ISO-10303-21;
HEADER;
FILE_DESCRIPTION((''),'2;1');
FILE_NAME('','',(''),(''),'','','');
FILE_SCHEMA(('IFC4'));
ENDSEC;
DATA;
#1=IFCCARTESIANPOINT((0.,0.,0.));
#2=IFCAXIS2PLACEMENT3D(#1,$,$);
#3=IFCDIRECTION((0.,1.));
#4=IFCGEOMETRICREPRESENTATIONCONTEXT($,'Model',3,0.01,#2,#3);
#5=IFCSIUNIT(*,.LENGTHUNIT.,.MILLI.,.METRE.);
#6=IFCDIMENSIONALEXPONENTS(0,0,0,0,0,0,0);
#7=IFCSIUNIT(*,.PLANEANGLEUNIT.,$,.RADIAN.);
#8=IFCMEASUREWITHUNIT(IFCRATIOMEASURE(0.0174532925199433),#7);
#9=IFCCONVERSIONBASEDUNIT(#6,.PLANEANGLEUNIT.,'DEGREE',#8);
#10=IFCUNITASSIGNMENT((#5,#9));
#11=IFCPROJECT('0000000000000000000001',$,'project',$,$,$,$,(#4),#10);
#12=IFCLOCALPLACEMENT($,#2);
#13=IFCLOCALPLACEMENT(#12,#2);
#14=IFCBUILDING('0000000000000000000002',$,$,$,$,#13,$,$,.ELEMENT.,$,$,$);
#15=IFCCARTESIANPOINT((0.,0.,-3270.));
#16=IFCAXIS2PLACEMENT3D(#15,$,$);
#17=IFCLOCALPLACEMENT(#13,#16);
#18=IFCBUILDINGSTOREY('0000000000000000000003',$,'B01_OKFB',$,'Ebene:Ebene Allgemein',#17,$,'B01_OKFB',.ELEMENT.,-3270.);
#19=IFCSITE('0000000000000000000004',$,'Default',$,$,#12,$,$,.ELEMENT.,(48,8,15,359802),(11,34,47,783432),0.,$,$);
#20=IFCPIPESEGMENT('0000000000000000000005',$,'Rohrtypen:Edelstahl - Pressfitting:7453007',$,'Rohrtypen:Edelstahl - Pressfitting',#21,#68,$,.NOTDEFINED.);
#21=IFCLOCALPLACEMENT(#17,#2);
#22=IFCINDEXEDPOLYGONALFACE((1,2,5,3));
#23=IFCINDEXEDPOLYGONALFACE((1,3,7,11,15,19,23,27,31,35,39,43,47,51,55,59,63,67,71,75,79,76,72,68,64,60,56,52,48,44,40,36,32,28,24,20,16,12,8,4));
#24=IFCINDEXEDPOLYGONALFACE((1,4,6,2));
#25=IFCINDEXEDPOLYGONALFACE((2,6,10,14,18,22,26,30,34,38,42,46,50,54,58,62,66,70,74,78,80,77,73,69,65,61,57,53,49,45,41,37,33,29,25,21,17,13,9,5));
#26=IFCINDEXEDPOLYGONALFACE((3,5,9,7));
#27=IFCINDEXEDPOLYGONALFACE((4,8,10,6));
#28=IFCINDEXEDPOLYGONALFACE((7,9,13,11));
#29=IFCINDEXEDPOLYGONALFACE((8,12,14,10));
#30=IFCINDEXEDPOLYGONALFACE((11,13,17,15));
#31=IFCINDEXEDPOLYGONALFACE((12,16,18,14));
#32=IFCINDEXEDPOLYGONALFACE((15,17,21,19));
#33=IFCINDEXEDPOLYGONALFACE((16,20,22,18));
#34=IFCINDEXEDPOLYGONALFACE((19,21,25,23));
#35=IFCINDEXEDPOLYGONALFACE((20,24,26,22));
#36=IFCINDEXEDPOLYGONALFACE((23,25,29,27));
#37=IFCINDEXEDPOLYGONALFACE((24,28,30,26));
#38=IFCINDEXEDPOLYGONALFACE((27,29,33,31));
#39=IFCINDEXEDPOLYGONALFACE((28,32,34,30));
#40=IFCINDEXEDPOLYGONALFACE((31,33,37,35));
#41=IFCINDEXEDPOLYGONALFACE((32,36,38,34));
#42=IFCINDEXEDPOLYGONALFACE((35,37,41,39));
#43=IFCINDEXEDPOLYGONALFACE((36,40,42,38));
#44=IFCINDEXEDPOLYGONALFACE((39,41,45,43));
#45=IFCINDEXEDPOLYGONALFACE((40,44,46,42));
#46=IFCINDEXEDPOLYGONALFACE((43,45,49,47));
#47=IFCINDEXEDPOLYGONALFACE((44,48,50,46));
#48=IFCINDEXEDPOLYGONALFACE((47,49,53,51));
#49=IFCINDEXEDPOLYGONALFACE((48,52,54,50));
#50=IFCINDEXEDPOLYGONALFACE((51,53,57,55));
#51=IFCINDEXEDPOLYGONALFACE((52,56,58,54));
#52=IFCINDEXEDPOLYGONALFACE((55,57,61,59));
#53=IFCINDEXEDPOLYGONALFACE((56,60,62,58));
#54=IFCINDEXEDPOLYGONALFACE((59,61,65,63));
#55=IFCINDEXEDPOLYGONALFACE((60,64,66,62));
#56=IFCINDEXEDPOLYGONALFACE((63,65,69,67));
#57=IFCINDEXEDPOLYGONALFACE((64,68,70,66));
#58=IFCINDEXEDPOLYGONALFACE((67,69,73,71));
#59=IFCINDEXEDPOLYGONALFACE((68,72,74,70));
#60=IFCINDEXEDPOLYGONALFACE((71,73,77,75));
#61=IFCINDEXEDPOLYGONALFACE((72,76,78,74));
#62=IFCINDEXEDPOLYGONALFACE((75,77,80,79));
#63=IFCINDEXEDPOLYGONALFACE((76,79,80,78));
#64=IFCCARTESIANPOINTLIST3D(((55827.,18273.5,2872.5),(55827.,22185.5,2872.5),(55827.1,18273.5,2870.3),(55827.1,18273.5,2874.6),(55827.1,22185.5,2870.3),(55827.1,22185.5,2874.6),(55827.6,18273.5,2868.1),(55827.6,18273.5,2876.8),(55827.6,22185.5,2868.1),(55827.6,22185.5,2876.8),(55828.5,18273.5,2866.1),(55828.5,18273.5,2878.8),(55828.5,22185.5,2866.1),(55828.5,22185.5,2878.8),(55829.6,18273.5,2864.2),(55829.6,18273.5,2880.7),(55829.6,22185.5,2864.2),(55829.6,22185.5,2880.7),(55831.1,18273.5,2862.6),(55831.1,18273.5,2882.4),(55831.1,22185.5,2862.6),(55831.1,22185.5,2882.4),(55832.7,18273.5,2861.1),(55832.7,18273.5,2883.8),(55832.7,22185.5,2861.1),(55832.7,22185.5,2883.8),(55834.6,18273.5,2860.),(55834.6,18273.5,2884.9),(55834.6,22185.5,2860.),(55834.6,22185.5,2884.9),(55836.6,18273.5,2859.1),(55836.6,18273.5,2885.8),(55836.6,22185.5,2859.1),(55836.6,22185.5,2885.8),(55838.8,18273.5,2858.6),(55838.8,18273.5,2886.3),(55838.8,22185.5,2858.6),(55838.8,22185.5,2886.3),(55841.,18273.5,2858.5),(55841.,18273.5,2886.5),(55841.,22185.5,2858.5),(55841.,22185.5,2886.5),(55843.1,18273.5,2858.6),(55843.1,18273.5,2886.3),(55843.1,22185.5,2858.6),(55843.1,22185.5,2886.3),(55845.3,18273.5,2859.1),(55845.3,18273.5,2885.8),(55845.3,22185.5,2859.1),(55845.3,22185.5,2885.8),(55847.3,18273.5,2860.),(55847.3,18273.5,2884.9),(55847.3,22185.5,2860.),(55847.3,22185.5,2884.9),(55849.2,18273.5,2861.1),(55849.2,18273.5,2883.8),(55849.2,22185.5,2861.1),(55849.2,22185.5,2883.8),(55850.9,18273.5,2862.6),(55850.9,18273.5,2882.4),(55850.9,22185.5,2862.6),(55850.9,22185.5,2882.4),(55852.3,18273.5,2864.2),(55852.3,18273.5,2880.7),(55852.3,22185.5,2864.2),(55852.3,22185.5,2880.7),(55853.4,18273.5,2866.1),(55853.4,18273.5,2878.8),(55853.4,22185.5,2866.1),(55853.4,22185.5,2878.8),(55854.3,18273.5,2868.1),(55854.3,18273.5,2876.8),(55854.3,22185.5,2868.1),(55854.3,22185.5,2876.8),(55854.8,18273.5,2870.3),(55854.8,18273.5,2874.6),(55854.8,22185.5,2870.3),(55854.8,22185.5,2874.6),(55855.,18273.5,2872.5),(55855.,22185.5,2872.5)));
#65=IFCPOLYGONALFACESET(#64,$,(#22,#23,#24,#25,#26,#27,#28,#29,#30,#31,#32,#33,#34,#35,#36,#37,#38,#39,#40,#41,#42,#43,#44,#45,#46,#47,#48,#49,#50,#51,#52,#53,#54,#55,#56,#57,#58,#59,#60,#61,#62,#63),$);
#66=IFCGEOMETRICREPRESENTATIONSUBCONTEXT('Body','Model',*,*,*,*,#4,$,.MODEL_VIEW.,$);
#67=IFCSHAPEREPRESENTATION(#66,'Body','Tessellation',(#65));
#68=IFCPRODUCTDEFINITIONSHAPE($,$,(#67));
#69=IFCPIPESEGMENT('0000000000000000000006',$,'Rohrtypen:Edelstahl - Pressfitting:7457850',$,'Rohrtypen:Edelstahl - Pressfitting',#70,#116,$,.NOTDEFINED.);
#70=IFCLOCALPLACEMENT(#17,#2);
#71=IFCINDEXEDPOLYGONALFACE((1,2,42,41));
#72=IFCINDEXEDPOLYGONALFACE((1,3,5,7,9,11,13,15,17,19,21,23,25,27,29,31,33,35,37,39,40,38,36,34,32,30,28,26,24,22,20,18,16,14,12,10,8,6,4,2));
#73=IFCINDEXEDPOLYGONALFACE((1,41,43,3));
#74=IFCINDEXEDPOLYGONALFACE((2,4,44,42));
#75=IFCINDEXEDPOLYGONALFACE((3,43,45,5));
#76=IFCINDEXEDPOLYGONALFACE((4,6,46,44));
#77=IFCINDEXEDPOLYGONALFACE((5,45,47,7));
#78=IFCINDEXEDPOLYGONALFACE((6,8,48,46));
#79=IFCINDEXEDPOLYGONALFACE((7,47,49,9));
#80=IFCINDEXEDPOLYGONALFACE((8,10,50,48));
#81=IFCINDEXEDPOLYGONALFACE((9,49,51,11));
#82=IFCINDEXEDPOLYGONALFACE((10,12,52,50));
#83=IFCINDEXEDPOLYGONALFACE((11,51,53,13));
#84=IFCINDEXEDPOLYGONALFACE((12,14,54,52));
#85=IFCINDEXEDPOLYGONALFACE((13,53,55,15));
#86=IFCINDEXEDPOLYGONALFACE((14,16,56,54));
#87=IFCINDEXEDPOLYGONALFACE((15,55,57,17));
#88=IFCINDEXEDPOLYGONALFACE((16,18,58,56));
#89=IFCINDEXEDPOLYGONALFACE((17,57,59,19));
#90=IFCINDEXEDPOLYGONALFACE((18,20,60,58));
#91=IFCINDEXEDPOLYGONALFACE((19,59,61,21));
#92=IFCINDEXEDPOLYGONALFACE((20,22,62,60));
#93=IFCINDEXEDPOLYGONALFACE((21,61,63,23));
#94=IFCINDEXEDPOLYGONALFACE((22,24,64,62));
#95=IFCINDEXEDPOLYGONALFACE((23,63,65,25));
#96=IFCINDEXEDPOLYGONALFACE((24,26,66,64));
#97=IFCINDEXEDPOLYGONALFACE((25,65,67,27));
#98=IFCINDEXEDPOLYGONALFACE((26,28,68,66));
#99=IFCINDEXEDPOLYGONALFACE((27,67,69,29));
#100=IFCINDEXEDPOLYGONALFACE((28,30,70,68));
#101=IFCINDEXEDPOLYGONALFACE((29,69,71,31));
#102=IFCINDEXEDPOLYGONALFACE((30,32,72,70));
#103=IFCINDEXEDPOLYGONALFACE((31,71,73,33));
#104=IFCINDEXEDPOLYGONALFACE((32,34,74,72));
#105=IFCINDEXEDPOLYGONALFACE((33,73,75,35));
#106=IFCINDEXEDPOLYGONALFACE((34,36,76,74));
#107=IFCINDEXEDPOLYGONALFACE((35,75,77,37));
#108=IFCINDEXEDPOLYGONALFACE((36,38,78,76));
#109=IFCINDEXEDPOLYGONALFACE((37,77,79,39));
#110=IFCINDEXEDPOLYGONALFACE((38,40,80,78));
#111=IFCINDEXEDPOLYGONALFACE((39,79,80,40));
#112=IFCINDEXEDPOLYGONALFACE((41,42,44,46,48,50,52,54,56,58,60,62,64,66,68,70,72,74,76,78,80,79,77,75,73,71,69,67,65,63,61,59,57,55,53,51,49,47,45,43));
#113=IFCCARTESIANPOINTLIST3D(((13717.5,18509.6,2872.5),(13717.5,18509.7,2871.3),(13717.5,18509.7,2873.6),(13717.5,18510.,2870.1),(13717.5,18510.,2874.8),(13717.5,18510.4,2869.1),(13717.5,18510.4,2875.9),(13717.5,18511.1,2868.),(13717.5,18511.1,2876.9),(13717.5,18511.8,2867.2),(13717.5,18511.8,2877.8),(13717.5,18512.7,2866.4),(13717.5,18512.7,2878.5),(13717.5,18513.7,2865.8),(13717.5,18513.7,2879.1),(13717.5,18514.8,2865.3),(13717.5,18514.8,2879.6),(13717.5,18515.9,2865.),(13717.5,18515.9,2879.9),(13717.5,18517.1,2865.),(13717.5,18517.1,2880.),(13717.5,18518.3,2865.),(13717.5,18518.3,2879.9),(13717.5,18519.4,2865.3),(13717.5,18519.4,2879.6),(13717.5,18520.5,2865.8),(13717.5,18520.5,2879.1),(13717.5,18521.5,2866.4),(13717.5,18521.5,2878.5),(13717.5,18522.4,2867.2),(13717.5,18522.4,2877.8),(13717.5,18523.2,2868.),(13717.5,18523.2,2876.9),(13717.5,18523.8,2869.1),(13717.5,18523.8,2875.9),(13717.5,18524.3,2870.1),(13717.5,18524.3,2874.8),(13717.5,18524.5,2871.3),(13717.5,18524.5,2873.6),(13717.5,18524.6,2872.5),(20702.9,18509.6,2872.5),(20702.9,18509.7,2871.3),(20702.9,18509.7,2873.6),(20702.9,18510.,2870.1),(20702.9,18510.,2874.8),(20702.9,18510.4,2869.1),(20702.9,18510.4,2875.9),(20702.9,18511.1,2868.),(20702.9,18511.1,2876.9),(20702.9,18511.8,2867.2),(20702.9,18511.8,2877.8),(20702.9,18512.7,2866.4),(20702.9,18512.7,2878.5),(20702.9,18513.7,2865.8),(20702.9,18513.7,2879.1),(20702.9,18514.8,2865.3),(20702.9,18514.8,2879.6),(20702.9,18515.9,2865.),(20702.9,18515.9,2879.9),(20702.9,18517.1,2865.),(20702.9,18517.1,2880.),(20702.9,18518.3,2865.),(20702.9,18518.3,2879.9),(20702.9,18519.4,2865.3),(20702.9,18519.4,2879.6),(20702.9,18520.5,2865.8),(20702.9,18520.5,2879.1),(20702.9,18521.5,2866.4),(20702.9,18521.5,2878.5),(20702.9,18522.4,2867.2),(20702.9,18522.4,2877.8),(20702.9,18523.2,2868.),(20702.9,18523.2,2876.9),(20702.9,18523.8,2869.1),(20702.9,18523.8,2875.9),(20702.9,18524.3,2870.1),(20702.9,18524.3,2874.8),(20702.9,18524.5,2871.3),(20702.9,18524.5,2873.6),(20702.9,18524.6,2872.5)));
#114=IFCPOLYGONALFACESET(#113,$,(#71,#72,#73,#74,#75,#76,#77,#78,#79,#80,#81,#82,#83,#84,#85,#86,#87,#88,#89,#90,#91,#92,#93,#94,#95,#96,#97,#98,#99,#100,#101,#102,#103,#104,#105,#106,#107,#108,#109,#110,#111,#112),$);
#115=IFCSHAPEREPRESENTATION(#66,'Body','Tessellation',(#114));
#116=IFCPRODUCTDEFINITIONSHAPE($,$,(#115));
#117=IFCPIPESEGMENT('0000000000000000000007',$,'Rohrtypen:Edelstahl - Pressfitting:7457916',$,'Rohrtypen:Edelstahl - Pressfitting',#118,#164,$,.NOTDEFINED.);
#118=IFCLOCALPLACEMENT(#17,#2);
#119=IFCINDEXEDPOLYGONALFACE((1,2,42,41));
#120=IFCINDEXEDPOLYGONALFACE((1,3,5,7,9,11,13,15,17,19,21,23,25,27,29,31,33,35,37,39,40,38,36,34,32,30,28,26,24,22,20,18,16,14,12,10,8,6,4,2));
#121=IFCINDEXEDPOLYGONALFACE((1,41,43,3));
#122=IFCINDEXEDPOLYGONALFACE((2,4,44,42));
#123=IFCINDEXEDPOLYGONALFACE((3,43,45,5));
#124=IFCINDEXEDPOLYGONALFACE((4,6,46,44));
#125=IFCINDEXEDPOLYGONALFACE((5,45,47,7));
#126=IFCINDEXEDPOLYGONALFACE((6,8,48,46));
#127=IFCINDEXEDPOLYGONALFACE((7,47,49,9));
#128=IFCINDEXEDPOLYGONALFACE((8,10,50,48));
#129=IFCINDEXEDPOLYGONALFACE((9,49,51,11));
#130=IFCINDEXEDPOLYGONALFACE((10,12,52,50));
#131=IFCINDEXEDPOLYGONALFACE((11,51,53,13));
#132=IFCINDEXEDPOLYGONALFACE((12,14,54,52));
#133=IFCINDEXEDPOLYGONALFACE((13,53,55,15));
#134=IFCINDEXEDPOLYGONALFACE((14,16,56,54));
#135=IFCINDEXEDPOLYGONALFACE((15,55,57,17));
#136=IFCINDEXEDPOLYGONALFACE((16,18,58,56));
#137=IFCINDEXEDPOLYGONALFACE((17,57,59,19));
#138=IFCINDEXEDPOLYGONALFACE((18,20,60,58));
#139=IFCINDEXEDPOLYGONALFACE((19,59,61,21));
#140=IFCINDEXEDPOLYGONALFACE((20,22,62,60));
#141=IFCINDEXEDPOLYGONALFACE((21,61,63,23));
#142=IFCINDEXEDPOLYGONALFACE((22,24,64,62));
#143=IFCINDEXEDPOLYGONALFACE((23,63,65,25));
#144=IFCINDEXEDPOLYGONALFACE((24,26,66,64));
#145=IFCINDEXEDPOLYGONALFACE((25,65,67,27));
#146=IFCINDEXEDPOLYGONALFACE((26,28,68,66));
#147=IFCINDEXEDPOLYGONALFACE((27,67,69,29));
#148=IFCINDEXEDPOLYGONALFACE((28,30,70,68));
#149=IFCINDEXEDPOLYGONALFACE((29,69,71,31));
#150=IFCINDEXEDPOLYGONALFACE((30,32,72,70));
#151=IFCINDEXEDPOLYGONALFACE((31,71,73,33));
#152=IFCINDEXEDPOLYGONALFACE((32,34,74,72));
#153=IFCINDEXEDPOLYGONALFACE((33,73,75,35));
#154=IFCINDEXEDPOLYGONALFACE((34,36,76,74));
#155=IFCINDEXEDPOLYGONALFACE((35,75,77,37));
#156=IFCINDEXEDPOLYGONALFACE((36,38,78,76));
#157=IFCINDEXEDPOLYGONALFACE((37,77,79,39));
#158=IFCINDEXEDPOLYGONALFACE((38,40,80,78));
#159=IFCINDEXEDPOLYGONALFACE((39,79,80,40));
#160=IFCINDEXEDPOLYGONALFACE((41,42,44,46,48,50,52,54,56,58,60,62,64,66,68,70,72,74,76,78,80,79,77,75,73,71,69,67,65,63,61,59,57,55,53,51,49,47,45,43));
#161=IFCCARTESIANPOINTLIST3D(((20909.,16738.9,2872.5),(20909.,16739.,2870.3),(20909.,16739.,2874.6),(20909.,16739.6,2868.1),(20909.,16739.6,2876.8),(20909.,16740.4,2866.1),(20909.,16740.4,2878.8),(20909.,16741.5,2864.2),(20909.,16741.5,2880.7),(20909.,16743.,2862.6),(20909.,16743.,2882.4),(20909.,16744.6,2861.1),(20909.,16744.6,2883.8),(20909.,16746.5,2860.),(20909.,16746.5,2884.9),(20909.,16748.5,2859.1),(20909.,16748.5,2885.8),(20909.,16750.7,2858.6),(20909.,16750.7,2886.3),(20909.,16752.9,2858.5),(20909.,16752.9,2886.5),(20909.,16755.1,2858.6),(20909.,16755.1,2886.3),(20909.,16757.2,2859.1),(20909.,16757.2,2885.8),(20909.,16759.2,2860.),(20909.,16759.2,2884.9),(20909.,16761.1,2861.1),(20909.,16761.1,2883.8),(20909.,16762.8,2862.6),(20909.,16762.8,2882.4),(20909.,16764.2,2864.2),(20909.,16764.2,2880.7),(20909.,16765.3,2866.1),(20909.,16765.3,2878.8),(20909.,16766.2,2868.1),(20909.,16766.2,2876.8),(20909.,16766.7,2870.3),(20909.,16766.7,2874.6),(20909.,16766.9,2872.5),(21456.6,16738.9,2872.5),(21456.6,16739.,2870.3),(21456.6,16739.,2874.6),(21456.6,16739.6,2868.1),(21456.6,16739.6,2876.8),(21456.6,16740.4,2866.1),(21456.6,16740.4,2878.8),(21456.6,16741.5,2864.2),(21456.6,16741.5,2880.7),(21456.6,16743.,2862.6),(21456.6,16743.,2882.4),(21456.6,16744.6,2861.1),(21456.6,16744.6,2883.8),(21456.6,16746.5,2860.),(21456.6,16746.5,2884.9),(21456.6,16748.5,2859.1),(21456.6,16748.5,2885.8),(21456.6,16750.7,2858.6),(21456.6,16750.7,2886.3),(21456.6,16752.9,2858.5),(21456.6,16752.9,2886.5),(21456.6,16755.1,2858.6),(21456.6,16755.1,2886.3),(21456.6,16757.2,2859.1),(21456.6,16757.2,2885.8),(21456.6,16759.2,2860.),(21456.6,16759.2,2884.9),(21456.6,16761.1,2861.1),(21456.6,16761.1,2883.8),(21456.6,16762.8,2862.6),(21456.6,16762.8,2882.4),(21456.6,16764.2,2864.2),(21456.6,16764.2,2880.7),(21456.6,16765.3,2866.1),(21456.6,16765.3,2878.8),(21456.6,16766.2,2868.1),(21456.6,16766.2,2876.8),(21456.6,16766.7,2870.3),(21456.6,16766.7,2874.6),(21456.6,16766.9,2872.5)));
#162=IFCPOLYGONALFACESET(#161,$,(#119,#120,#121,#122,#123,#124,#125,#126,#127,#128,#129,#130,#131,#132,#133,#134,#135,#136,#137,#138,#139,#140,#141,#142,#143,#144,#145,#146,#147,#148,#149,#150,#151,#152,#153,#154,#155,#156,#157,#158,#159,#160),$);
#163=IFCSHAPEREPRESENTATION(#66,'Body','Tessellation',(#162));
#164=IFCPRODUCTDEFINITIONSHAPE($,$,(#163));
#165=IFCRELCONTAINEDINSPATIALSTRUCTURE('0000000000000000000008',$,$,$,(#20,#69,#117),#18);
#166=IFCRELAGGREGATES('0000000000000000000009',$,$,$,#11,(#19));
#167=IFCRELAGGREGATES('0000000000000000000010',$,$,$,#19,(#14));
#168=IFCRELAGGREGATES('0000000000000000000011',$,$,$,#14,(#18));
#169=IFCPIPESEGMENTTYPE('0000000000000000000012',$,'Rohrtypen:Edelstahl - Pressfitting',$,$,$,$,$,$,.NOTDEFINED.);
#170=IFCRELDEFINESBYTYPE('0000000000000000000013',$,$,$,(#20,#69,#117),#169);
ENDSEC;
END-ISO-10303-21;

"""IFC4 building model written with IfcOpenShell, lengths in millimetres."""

from ifc_helpers import new_model, entity, si_unit, converted_unit, direction, frame, origin, place, context, subcontext, project, spatial, indexed_curve, outline, extrude, type_object, element, save


model = new_model("IFC4")

# Units and contexts
model_context = context("Model", 3, precision=0.01, world=origin(), true_north=direction((0.0, 1.0)))
body_context = subcontext(model_context, "Body", "Model", "MODEL_VIEW")
ifc_project = project(units=[si_unit("LENGTHUNIT", "METRE", prefix="MILLI"), converted_unit("PLANEANGLEUNIT", "DEGREE", entity("IfcRatioMeasure", 0.0174532925199433), si_unit("PLANEANGLEUNIT", "RADIAN"), dimensions=[0, 0, 0, 0, 0, 0, 0])], contexts=[model_context])

# Site, building, storey
site_placement = place(None, origin())
site = spatial("IfcSite", under=ifc_project, at=site_placement, Name="Default", CompositionType="ELEMENT", RefLatitude=(48, 8, 15, 359802), RefLongitude=(11, 34, 47, 783432), RefElevation=0.0)
building_placement = place(site_placement, origin())
building = spatial("IfcBuilding", under=site, at=building_placement, CompositionType="ELEMENT")
storey_placement = place(building_placement, frame((0.0, 0.0, -3270.0)))
storey = spatial("IfcBuildingStorey", under=building, at=storey_placement, Name="B01_OKFB", ObjectType="Ebene:Ebene Allgemein", LongName="B01_OKFB", CompositionType="ELEMENT", Elevation=-3270.0)

# Pipe segments
pipe_segment_type_1 = type_object("IfcPipeSegmentType", Name="Rohrtypen:Edelstahl - Pressfitting", PredefinedType="NOTDEFINED")
pipe_segment_1_placement = place(storey_placement, origin())
element("IfcPipeSegment", 1, at=pipe_segment_1_placement, inside=storey, type_object=pipe_segment_type_1, Name="Rohrtypen:Edelstahl - Pressfitting:7453007", ObjectType="Rohrtypen:Edelstahl - Pressfitting", PredefinedType="NOTDEFINED", context=body_context, shape_type="SweptSolid", body=[
    extrude(outline(indexed_curve([(14.0, 0.0), (13.8, 2.2), (13.3, 4.3), (12.5, 6.4), (11.3, 8.2), (9.9, 9.9), (8.2, 11.3), (6.4, 12.5), (4.3, 13.3), (2.2, 13.8), (0.0, 14.0), (-2.2, 13.8), (-4.3, 13.3), (-6.4, 12.5), (-8.2, 11.3), (-9.9, 9.9), (-11.3, 8.2), (-12.5, 6.4), (-13.3, 4.3), (-13.8, 2.2), (-14.0, 0.0), (-13.8, -2.2), (-13.3, -4.3), (-12.5, -6.4), (-11.3, -8.2), (-9.9, -9.9), (-8.2, -11.3), (-6.4, -12.5), (-4.3, -13.3), (-2.2, -13.8), (0.0, -14.0), (2.2, -13.8), (4.3, -13.3), (6.4, -12.5), (8.2, -11.3), (9.9, -9.9), (11.3, -8.2), (12.5, -6.4), (13.3, -4.3), (13.8, -2.2), (14.0, 0.0)], self_intersect=False)), frame((55841.0, 18273.5, 2872.5), z_axis=(0.0, 1.0, 0.0), x_axis=(-1.0, 0.0, 0.0)), (0.0, 0.0, 1.0), 3912.0),
])
pipe_segment_2_placement = place(storey_placement, origin())
element("IfcPipeSegment", 2, at=pipe_segment_2_placement, inside=storey, type_object=pipe_segment_type_1, Name="Rohrtypen:Edelstahl - Pressfitting:7457850", ObjectType="Rohrtypen:Edelstahl - Pressfitting", PredefinedType="NOTDEFINED", context=body_context, shape_type="SweptSolid", body=[
    extrude(outline(indexed_curve([(7.5, 0.0), (7.4, 1.2), (7.1, 2.3), (6.7, 3.4), (6.1, 4.4), (5.3, 5.3), (4.4, 6.1), (3.4, 6.7), (2.3, 7.1), (1.2, 7.4), (0.0, 7.5), (-1.2, 7.4), (-2.3, 7.1), (-3.4, 6.7), (-4.4, 6.1), (-5.3, 5.3), (-6.1, 4.4), (-6.7, 3.4), (-7.1, 2.3), (-7.4, 1.2), (-7.5, 0.0), (-7.4, -1.2), (-7.1, -2.3), (-6.7, -3.4), (-6.1, -4.4), (-5.3, -5.3), (-4.4, -6.1), (-3.4, -6.7), (-2.3, -7.1), (-1.2, -7.4), (0.0, -7.5), (1.2, -7.4), (2.3, -7.1), (3.4, -6.7), (4.4, -6.1), (5.3, -5.3), (6.1, -4.4), (6.7, -3.4), (7.1, -2.3), (7.4, -1.2), (7.5, 0.0)], self_intersect=False)), frame((13717.5, 18517.1, 2872.5), z_axis=(1.0, 0.0, 0.0), x_axis=(0.0, -1.0, 0.0)), (0.0, 0.0, 1.0), 6985.4),
])
pipe_segment_3_placement = place(storey_placement, origin())
element("IfcPipeSegment", 3, at=pipe_segment_3_placement, inside=storey, type_object=pipe_segment_type_1, Name="Rohrtypen:Edelstahl - Pressfitting:7457916", ObjectType="Rohrtypen:Edelstahl - Pressfitting", PredefinedType="NOTDEFINED", context=body_context, shape_type="SweptSolid", body=[
    extrude(outline(indexed_curve([(14.0, 0.0), (13.8, 2.2), (13.3, 4.3), (12.5, 6.4), (11.3, 8.2), (9.9, 9.9), (8.2, 11.3), (6.4, 12.5), (4.3, 13.3), (2.2, 13.8), (0.0, 14.0), (-2.2, 13.8), (-4.3, 13.3), (-6.4, 12.5), (-8.2, 11.3), (-9.9, 9.9), (-11.3, 8.2), (-12.5, 6.4), (-13.3, 4.3), (-13.8, 2.2), (-14.0, 0.0), (-13.8, -2.2), (-13.3, -4.3), (-12.5, -6.4), (-11.3, -8.2), (-9.9, -9.9), (-8.2, -11.3), (-6.4, -12.5), (-4.3, -13.3), (-2.2, -13.8), (0.0, -14.0), (2.2, -13.8), (4.3, -13.3), (6.4, -12.5), (8.2, -11.3), (9.9, -9.9), (11.3, -8.2), (12.5, -6.4), (13.3, -4.3), (13.8, -2.2), (14.0, 0.0)], self_intersect=False)), frame((20909.0, 16752.9, 2872.5), z_axis=(1.0, 0.0, 0.0), x_axis=(0.0, -1.0, 0.0)), (0.0, 0.0, 1.0), 547.6),
])

save(model, "model.ifc")
